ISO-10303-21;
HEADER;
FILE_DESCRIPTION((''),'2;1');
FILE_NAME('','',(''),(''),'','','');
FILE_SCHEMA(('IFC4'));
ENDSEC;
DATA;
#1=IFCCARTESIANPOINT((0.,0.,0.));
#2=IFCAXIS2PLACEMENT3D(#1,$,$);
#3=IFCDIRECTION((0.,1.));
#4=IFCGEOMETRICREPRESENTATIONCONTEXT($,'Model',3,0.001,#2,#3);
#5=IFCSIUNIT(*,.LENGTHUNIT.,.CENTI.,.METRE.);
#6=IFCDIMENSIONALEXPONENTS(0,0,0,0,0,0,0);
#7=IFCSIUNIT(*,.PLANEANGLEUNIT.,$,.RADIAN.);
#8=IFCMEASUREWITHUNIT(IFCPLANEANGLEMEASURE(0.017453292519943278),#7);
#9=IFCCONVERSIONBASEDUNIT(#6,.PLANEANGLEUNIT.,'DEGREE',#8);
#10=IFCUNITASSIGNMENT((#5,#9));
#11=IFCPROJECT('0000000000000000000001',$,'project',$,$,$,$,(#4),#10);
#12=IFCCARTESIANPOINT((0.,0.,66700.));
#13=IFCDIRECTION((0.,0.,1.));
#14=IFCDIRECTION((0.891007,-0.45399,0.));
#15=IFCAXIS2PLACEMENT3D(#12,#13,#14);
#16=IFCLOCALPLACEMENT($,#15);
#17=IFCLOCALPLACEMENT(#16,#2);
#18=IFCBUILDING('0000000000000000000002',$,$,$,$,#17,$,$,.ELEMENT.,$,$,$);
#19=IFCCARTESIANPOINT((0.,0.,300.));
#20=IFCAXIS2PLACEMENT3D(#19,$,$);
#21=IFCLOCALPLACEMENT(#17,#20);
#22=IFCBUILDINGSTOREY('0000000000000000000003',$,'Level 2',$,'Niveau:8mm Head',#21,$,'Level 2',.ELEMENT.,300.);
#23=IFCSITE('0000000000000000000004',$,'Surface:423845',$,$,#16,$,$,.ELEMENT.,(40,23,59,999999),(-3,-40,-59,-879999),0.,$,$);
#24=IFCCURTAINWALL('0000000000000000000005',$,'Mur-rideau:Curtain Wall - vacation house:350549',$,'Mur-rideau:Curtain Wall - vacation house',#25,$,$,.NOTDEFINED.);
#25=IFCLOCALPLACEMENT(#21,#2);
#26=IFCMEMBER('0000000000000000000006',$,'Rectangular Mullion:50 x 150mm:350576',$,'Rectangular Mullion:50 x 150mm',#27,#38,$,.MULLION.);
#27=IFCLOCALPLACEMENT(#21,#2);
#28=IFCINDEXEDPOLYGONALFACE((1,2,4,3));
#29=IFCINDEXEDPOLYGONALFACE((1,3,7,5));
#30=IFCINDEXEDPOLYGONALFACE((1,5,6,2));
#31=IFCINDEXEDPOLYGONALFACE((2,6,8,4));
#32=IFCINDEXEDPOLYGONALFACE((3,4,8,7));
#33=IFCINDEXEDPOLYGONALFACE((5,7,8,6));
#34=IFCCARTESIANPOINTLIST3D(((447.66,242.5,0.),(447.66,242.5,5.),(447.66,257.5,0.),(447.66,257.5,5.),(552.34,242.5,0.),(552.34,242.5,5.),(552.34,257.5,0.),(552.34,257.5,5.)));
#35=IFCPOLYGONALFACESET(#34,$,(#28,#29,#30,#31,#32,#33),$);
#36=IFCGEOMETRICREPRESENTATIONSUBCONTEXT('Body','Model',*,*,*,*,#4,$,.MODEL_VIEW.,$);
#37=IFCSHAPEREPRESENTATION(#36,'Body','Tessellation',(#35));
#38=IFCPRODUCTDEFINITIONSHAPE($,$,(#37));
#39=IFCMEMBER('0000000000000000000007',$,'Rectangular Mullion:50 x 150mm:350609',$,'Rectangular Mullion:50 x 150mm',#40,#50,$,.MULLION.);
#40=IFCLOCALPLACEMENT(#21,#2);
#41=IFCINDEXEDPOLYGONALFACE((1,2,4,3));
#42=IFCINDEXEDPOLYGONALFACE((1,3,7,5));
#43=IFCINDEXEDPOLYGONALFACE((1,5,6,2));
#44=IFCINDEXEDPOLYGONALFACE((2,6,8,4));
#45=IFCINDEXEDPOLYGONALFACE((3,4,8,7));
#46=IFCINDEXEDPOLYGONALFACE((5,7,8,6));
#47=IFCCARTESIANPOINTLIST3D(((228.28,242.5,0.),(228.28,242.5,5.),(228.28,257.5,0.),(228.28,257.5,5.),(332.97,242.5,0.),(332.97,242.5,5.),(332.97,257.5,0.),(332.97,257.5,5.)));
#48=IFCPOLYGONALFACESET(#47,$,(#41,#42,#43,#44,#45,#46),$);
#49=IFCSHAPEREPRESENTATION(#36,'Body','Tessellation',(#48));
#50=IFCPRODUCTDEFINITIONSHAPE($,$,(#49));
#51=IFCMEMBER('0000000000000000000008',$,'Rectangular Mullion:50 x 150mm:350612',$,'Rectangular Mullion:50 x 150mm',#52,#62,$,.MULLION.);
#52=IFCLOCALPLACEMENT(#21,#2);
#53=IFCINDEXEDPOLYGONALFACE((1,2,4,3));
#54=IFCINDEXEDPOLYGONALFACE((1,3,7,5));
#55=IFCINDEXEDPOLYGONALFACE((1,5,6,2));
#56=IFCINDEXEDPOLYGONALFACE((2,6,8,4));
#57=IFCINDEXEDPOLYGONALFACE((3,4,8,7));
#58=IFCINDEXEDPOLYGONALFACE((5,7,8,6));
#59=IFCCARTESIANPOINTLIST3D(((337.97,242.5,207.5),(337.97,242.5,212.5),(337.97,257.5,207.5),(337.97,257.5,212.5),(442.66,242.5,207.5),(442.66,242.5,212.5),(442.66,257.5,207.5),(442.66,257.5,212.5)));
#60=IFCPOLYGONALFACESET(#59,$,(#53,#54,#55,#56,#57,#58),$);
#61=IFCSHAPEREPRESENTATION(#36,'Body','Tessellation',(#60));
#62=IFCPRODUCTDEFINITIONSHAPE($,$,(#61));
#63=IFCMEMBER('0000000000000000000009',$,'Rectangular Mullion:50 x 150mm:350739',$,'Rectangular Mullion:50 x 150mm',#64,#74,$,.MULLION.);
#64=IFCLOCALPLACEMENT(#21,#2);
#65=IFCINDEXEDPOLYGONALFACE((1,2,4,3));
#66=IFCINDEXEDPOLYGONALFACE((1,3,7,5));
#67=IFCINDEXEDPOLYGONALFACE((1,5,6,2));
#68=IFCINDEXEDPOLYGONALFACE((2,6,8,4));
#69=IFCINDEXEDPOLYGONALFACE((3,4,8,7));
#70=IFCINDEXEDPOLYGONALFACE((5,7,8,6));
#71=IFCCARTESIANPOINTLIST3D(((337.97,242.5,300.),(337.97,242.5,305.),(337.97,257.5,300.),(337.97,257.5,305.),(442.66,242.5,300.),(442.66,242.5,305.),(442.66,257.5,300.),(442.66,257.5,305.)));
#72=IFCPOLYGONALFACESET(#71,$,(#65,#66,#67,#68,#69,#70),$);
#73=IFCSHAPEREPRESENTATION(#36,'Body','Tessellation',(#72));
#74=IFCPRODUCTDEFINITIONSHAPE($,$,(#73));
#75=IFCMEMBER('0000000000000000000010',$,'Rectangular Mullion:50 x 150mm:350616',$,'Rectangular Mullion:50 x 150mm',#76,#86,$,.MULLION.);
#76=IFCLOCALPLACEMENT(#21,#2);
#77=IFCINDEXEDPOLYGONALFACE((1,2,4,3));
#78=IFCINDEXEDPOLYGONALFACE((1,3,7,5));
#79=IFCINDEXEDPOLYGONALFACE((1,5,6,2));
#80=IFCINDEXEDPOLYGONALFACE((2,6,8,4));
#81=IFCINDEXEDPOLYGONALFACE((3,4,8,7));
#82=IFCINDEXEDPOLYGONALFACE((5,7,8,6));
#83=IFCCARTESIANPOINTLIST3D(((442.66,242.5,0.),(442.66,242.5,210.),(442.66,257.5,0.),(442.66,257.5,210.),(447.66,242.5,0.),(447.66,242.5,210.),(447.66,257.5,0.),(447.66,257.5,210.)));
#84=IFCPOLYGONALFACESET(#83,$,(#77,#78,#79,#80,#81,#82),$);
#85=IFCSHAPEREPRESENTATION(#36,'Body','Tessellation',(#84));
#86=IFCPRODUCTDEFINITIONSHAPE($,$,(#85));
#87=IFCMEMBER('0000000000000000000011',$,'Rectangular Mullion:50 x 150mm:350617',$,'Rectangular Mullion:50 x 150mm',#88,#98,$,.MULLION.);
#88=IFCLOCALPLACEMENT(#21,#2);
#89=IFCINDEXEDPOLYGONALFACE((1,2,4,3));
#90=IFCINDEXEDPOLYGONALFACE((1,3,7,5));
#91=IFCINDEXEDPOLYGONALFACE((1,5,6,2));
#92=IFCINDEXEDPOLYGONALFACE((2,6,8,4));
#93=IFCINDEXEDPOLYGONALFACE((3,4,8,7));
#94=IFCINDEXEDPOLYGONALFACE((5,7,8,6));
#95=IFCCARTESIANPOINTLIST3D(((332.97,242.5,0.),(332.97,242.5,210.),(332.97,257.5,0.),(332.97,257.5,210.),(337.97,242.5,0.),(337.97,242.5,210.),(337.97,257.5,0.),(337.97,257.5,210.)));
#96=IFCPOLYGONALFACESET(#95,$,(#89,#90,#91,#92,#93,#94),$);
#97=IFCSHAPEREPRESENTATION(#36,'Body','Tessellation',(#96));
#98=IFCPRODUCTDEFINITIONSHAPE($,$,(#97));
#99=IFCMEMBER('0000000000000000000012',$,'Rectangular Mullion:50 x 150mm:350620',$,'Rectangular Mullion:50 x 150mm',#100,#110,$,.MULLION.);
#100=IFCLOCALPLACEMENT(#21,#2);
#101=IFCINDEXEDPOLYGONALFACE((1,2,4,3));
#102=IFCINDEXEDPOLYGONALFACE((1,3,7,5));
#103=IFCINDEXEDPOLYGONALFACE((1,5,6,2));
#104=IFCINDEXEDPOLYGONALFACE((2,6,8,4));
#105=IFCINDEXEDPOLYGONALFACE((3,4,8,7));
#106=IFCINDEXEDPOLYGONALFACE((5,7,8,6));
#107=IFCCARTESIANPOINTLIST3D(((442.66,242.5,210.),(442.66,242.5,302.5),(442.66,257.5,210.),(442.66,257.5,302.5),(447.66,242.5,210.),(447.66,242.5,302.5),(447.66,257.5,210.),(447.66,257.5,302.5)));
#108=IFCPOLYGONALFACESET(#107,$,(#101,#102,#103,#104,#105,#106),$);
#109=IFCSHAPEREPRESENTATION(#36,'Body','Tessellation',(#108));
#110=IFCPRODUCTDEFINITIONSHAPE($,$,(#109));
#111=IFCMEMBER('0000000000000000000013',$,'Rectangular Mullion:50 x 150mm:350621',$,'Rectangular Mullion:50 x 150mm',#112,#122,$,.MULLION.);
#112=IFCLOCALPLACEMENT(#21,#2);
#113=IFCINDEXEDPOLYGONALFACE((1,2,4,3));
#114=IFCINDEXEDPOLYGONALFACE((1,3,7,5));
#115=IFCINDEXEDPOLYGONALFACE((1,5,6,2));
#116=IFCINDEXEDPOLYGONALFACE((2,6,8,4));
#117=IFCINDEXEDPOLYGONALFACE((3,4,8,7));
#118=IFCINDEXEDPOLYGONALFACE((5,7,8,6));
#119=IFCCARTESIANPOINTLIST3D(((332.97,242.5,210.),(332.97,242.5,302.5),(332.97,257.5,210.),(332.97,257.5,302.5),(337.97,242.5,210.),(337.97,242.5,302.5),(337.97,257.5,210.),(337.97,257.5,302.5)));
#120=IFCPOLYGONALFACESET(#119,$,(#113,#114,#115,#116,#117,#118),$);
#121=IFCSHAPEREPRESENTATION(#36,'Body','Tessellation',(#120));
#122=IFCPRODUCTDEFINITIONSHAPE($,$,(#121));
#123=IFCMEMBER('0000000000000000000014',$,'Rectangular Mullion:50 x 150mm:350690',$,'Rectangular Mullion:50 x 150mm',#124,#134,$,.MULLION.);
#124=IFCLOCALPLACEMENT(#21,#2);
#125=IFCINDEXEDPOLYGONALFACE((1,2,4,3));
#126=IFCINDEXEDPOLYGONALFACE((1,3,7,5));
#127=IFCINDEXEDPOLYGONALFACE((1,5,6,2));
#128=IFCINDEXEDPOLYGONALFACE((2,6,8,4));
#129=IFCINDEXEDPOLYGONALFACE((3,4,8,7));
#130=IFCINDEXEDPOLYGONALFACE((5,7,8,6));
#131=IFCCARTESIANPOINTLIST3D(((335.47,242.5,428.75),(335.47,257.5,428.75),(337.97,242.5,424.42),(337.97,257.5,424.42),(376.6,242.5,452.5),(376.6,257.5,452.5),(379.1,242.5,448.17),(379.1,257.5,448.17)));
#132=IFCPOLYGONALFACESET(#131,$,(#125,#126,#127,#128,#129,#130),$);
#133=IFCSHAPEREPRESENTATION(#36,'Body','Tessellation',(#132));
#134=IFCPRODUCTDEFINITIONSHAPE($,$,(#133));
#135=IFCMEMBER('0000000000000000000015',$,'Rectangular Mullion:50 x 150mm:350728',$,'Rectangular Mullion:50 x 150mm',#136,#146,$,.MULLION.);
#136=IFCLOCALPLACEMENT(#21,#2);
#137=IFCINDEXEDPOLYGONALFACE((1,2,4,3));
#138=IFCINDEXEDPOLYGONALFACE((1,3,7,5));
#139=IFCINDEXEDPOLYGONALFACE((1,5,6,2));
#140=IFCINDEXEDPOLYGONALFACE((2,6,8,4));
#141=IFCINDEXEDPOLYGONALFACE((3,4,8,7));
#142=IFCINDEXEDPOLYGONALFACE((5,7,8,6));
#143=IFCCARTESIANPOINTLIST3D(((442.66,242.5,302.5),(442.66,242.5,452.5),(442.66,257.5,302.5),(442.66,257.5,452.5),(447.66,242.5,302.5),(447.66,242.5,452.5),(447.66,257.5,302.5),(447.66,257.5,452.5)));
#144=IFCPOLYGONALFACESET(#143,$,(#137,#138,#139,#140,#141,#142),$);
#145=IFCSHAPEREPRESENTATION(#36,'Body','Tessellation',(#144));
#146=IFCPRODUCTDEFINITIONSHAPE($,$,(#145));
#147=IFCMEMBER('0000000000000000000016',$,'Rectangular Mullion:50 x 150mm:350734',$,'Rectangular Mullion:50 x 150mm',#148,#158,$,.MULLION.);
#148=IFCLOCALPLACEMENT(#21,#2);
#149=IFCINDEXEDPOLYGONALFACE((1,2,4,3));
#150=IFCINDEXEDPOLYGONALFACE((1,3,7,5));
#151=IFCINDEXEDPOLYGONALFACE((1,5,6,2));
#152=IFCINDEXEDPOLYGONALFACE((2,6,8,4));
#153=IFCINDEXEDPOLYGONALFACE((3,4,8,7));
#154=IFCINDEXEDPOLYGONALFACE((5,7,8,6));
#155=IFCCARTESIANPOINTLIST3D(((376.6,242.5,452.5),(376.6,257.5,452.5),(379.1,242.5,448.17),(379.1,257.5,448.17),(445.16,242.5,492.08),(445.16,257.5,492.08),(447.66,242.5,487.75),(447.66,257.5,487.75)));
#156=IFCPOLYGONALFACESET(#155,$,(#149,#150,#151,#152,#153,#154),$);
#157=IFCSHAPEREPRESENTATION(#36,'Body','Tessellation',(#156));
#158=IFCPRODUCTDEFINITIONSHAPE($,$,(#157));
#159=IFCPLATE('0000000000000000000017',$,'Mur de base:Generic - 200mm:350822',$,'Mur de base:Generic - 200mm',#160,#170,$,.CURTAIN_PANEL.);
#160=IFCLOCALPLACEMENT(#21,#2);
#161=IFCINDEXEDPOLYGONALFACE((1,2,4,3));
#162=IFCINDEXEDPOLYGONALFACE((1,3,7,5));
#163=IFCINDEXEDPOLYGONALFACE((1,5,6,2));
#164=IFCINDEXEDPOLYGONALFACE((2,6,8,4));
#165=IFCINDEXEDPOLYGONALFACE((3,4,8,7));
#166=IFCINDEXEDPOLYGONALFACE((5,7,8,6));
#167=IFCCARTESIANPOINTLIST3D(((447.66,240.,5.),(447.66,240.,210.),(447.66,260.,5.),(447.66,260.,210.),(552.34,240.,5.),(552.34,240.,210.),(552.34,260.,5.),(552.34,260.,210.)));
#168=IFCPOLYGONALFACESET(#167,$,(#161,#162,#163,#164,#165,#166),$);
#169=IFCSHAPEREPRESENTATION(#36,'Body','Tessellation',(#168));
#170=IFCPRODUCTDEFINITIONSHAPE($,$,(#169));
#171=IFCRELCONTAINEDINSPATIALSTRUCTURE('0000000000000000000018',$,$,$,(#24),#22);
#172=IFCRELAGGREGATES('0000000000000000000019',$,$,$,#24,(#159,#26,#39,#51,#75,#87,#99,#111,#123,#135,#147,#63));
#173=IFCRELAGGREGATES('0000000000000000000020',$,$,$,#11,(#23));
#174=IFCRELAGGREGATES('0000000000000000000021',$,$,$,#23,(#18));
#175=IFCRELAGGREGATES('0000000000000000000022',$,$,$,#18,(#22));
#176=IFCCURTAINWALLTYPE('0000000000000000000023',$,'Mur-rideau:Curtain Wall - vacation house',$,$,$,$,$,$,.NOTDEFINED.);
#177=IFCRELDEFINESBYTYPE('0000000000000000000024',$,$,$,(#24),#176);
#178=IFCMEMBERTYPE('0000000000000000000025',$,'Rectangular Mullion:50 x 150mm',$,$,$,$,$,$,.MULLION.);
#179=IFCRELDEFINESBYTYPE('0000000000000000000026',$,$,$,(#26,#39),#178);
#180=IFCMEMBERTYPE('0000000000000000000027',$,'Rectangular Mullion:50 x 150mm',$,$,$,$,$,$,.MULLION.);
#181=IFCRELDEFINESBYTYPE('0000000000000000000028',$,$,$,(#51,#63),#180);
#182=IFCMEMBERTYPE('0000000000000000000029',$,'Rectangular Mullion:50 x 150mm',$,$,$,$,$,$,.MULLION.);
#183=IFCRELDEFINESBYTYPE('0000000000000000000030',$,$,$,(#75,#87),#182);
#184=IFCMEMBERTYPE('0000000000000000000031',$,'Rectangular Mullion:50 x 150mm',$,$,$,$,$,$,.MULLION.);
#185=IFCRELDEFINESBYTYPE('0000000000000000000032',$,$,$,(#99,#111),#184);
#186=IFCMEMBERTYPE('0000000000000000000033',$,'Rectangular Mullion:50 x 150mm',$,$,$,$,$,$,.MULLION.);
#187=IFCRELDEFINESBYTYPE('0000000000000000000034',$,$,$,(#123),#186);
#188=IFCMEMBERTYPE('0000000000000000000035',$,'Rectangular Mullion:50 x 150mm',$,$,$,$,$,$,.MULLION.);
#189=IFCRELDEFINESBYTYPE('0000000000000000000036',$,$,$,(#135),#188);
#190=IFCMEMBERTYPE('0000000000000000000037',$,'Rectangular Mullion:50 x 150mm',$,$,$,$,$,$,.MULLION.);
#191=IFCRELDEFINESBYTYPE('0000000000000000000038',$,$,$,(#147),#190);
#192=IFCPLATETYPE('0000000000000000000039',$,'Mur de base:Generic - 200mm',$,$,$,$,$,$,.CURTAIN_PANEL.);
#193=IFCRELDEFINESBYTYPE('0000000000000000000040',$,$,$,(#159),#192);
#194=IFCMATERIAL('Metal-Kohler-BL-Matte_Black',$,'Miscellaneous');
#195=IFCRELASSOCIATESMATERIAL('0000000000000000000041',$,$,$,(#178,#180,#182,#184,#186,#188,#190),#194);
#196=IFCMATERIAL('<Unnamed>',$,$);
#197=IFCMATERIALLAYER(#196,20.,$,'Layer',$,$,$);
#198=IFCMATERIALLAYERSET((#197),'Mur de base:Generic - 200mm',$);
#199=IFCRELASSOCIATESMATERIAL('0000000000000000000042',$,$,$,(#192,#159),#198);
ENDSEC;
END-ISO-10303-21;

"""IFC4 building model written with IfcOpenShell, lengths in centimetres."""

from ifc_helpers import new_model, entity, si_unit, converted_unit, direction, frame, origin, origin_2d_with_axis, place, context, subcontext, project, spatial, rectangle, extrude, source, transform, mapped, material, layer, layer_set, layer_usage, material_profile, profile_set, type_object, type_shapes, element, aggregate, save


model = new_model("IFC4")

# Units and contexts
model_context = context("Model", 3, precision=0.001, world=origin(), true_north=direction((0.0, 1.0)))
body_context = subcontext(model_context, "Body", "Model", "MODEL_VIEW")
ifc_project = project(units=[si_unit("LENGTHUNIT", "METRE", prefix="CENTI"), converted_unit("PLANEANGLEUNIT", "DEGREE", entity("IfcPlaneAngleMeasure", 0.017453292519943278), si_unit("PLANEANGLEUNIT", "RADIAN"), dimensions=[0, 0, 0, 0, 0, 0, 0])], contexts=[model_context])

# Site, building, storey
site_placement = place(None, frame((0.0, 0.0, 66700.0), z_axis=(0.0, 0.0, 1.0), x_axis=(0.891007, -0.45399, 0.0)))
site = spatial("IfcSite", under=ifc_project, at=site_placement, Name="Surface:423845", CompositionType="ELEMENT", RefLatitude=(40, 23, 59, 999999), RefLongitude=(-3, -40, -59, -879999), RefElevation=0.0)
building_placement = place(site_placement, origin())
building = spatial("IfcBuilding", under=site, at=building_placement, CompositionType="ELEMENT")
storey_placement = place(building_placement, frame((0.0, 0.0, 300.0)))
storey = spatial("IfcBuildingStorey", under=building, at=storey_placement, Name="Level 2", ObjectType="Niveau:8mm Head", LongName="Level 2", CompositionType="ELEMENT", Elevation=300.0)

# Curtain wall, members
curtain_wall_type = type_object("IfcCurtainWallType", Name="Mur-rideau:Curtain Wall - vacation house", PredefinedType="NOTDEFINED")
curtain_wall_placement = place(storey_placement, frame((0.0, 0.0, -300.0)))
curtain_wall = element("IfcCurtainWall", 1, at=curtain_wall_placement, inside=storey, type_object=curtain_wall_type, Name="Mur-rideau:Curtain Wall - vacation house:350549", ObjectType="Mur-rideau:Curtain Wall - vacation house", PredefinedType="NOTDEFINED")
ifc_material_1 = material(Name="Metal-Kohler-BL-Matte_Black", Category="Miscellaneous")
ifc_material_profile = material_profile(ifc_material_1, rectangle(XDim=5.0, YDim=15.0, at=origin_2d_with_axis()), Name="50 x 150mm")
ifc_profile_set = profile_set([ifc_material_profile], Name="50 x 150mm")
member_type_1 = type_object("IfcMemberType", Name="Rectangular Mullion:50 x 150mm", PredefinedType="MULLION", material=ifc_profile_set)
shared_shape_1 = source(origin(), body_context, "Body", "SweptSolid", [
    extrude(rectangle(XDim=5.0, YDim=15.0, at=origin_2d_with_axis()), frame((-2.5, 0.0, -104.69), z_axis=(0.0, 0.0, 1.0), x_axis=(-1.0, 0.0, 0.0)), (0.0, 0.0, 1.0), 104.69),
])
type_shapes(member_type_1, [shared_shape_1])
member_1_placement = place(curtain_wall_placement, frame((552.34, 250.0, 300.0), z_axis=(1.0, 0.0, 0.0), x_axis=(0.0, 0.0, -1.0)))
member_1 = element("IfcMember", 2, at=member_1_placement, type_object=member_type_1, Name="Rectangular Mullion:50 x 150mm:350576", ObjectType="Rectangular Mullion:50 x 150mm", PredefinedType="MULLION", context=body_context, shape_type="MappedRepresentation", body=[
    mapped(shared_shape_1, transform((0.0, 0.0, 0.0), scale=1.0)),
])
member_2_placement = place(curtain_wall_placement, frame((332.97, 250.0, 300.0), z_axis=(1.0, 0.0, 0.0), x_axis=(0.0, 0.0, -1.0)))
member_2 = element("IfcMember", 3, at=member_2_placement, type_object=member_type_1, Name="Rectangular Mullion:50 x 150mm:350609", ObjectType="Rectangular Mullion:50 x 150mm", PredefinedType="MULLION", context=body_context, shape_type="MappedRepresentation", body=[
    mapped(shared_shape_1, transform((0.0, 0.0, 0.0), scale=1.0)),
])
member_type_2 = type_object("IfcMemberType", Name="Rectangular Mullion:50 x 150mm", PredefinedType="MULLION", material=ifc_profile_set)
shared_shape_2 = source(origin(), body_context, "Body", "SweptSolid", [
    extrude(rectangle(XDim=5.0, YDim=15.0, at=origin_2d_with_axis()), frame((0.0, 0.0, -104.69), z_axis=(0.0, 0.0, 1.0), x_axis=(-1.0, 0.0, 0.0)), (0.0, 0.0, 1.0), 104.69),
])
type_shapes(member_type_2, [shared_shape_2])
member_3_placement = place(curtain_wall_placement, frame((337.97, 250.0, 510.0), z_axis=(-1.0, 0.0, 0.0), x_axis=(0.0, 0.0, 1.0)))
member_3 = element("IfcMember", 4, at=member_3_placement, type_object=member_type_2, Name="Rectangular Mullion:50 x 150mm:350612", ObjectType="Rectangular Mullion:50 x 150mm", PredefinedType="MULLION", context=body_context, shape_type="MappedRepresentation", body=[
    mapped(shared_shape_2, transform((0.0, 0.0, 0.0), scale=1.0)),
])
member_4_placement = place(curtain_wall_placement, frame((337.97, 250.0, 602.5), z_axis=(-1.0, 0.0, 0.0), x_axis=(0.0, 0.0, 1.0)))
member_4 = element("IfcMember", 5, at=member_4_placement, type_object=member_type_2, Name="Rectangular Mullion:50 x 150mm:350739", ObjectType="Rectangular Mullion:50 x 150mm", PredefinedType="MULLION", context=body_context, shape_type="MappedRepresentation", body=[
    mapped(shared_shape_2, transform((0.0, 0.0, 0.0), scale=1.0)),
])
member_type_3 = type_object("IfcMemberType", Name="Rectangular Mullion:50 x 150mm", PredefinedType="MULLION", material=ifc_profile_set)
shared_shape_3 = source(origin(), body_context, "Body", "SweptSolid", [
    extrude(rectangle(XDim=5.0, YDim=15.0, at=origin_2d_with_axis()), frame((0.0, 0.0, -210.0), z_axis=(0.0, 0.0, 1.0), x_axis=(-1.0, 0.0, 0.0)), (0.0, 0.0, 1.0), 210.0),
])
type_shapes(member_type_3, [shared_shape_3])
member_5_placement = place(curtain_wall_placement, frame((445.16, 250.0, 300.0), z_axis=(0.0, 0.0, -1.0), x_axis=(-1.0, 0.0, 0.0)))
member_5 = element("IfcMember", 6, at=member_5_placement, type_object=member_type_3, Name="Rectangular Mullion:50 x 150mm:350616", ObjectType="Rectangular Mullion:50 x 150mm", PredefinedType="MULLION", context=body_context, shape_type="MappedRepresentation", body=[
    mapped(shared_shape_3, transform((0.0, 0.0, 0.0), scale=1.0)),
])
member_6_placement = place(curtain_wall_placement, frame((335.47, 250.0, 300.0), z_axis=(0.0, 0.0, -1.0), x_axis=(-1.0, 0.0, 0.0)))
member_6 = element("IfcMember", 7, at=member_6_placement, type_object=member_type_3, Name="Rectangular Mullion:50 x 150mm:350617", ObjectType="Rectangular Mullion:50 x 150mm", PredefinedType="MULLION", context=body_context, shape_type="MappedRepresentation", body=[
    mapped(shared_shape_3, transform((0.0, 0.0, 0.0), scale=1.0)),
])
member_type_4 = type_object("IfcMemberType", Name="Rectangular Mullion:50 x 150mm", PredefinedType="MULLION", material=ifc_profile_set)
shared_shape_4 = source(origin(), body_context, "Body", "SweptSolid", [
    extrude(rectangle(XDim=5.0, YDim=15.0, at=origin_2d_with_axis()), frame((0.0, 0.0, -92.5), z_axis=(0.0, 0.0, 1.0), x_axis=(-1.0, 0.0, 0.0)), (0.0, 0.0, 1.0), 92.5),
])
type_shapes(member_type_4, [shared_shape_4])
member_7_placement = place(curtain_wall_placement, frame((445.16, 250.0, 510.0), z_axis=(0.0, 0.0, -1.0), x_axis=(-1.0, 0.0, 0.0)))
member_7 = element("IfcMember", 8, at=member_7_placement, type_object=member_type_4, Name="Rectangular Mullion:50 x 150mm:350620", ObjectType="Rectangular Mullion:50 x 150mm", PredefinedType="MULLION", context=body_context, shape_type="MappedRepresentation", body=[
    mapped(shared_shape_4, transform((0.0, 0.0, 0.0), scale=1.0)),
])
member_8_placement = place(curtain_wall_placement, frame((335.47, 250.0, 510.0), z_axis=(0.0, 0.0, -1.0), x_axis=(-1.0, 0.0, 0.0)))
member_8 = element("IfcMember", 9, at=member_8_placement, type_object=member_type_4, Name="Rectangular Mullion:50 x 150mm:350621", ObjectType="Rectangular Mullion:50 x 150mm", PredefinedType="MULLION", context=body_context, shape_type="MappedRepresentation", body=[
    mapped(shared_shape_4, transform((0.0, 0.0, 0.0), scale=1.0)),
])
member_type_5 = type_object("IfcMemberType", Name="Rectangular Mullion:50 x 150mm", PredefinedType="MULLION", material=ifc_profile_set)
shared_shape_5 = source(origin(), body_context, "Body", "SweptSolid", [
    extrude(rectangle(XDim=5.0, YDim=15.0, at=origin_2d_with_axis()), frame((-2.5, 0.0, -47.5), z_axis=(0.0, 0.0, 1.0), x_axis=(-1.0, 0.0, 0.0)), (0.0, 0.0, 1.0), 47.5),
])
type_shapes(member_type_5, [shared_shape_5])
member_9_placement = place(curtain_wall_placement, frame((335.47, 250.0, 728.75), z_axis=(-0.866025, 0.0, -0.5), x_axis=(-0.5, 0.0, 0.866025)))
member_9 = element("IfcMember", 10, at=member_9_placement, type_object=member_type_5, Name="Rectangular Mullion:50 x 150mm:350690", ObjectType="Rectangular Mullion:50 x 150mm", PredefinedType="MULLION", context=body_context, shape_type="MappedRepresentation", body=[
    mapped(shared_shape_5, transform((0.0, 0.0, 0.0), scale=1.0)),
])
member_type_6 = type_object("IfcMemberType", Name="Rectangular Mullion:50 x 150mm", PredefinedType="MULLION", material=ifc_profile_set)
shared_shape_6 = source(origin(), body_context, "Body", "SweptSolid", [
    extrude(rectangle(XDim=5.0, YDim=15.0, at=origin_2d_with_axis()), frame((0.0, 0.0, -150.0), z_axis=(0.0, 0.0, 1.0), x_axis=(-1.0, 0.0, 0.0)), (0.0, 0.0, 1.0), 150.0),
])
type_shapes(member_type_6, [shared_shape_6])
member_10_placement = place(curtain_wall_placement, frame((445.16, 250.0, 602.5), z_axis=(0.0, 0.0, -1.0), x_axis=(-1.0, 0.0, 0.0)))
member_10 = element("IfcMember", 11, at=member_10_placement, type_object=member_type_6, Name="Rectangular Mullion:50 x 150mm:350728", ObjectType="Rectangular Mullion:50 x 150mm", PredefinedType="MULLION", context=body_context, shape_type="MappedRepresentation", body=[
    mapped(shared_shape_6, transform((0.0, 0.0, 0.0), scale=1.0)),
])
member_type_7 = type_object("IfcMemberType", Name="Rectangular Mullion:50 x 150mm", PredefinedType="MULLION", material=ifc_profile_set)
shared_shape_7 = source(origin(), body_context, "Body", "SweptSolid", [
    extrude(rectangle(XDim=5.0, YDim=15.0, at=origin_2d_with_axis()), frame((-2.5, 0.0, -79.16), z_axis=(0.0, 0.0, 1.0), x_axis=(-1.0, 0.0, 0.0)), (0.0, 0.0, 1.0), 79.16),
])
type_shapes(member_type_7, [shared_shape_7])
member_11_placement = place(curtain_wall_placement, frame((376.6, 250.0, 752.5), z_axis=(-0.866025, 0.0, -0.5), x_axis=(-0.5, 0.0, 0.866025)))
member_11 = element("IfcMember", 12, at=member_11_placement, type_object=member_type_7, Name="Rectangular Mullion:50 x 150mm:350734", ObjectType="Rectangular Mullion:50 x 150mm", PredefinedType="MULLION", context=body_context, shape_type="MappedRepresentation", body=[
    mapped(shared_shape_7, transform((0.0, 0.0, 0.0), scale=1.0)),
])

# Plate
ifc_material_2 = material(Name="<Unnamed>")
ifc_layer_1 = layer(ifc_material_2, 20.0, Name="Layer")
ifc_layer_set_1 = layer_set([ifc_layer_1], Name="Mur de base:Generic - 200mm")
ifc_layer_usage_1 = layer_usage(ifc_layer_set_1, "AXIS2", "NEGATIVE", 10.0)
plate_type_1 = type_object("IfcPlateType", Name="Mur de base:Generic - 200mm", PredefinedType="CURTAIN_PANEL", material=ifc_layer_set_1)
plate_1_placement = place(storey_placement, frame((552.34, 250.0, 5.0), z_axis=(0.0, 0.0, 1.0), x_axis=(-1.0, 0.0, 0.0)))
plate_1 = element("IfcPlate", 13, at=plate_1_placement, type_object=plate_type_1, material=ifc_layer_usage_1, Name="Mur de base:Generic - 200mm:350822", ObjectType="Mur de base:Generic - 200mm", PredefinedType="CURTAIN_PANEL", context=body_context, shape_type="SweptSolid", body=[
    extrude(rectangle(XDim=20.0, YDim=104.69, at=origin_2d_with_axis()), frame((52.34, 0.0, 0.0), z_axis=(0.0, 0.0, 1.0), x_axis=(0.0, 1.0, 0.0)), (0.0, 0.0, 1.0), 205.0),
])

aggregate(curtain_wall, [plate_1, member_1, member_2, member_3, member_5, member_6, member_7, member_8, member_9, member_10, member_11, member_4])

save(model, "model.ifc")
